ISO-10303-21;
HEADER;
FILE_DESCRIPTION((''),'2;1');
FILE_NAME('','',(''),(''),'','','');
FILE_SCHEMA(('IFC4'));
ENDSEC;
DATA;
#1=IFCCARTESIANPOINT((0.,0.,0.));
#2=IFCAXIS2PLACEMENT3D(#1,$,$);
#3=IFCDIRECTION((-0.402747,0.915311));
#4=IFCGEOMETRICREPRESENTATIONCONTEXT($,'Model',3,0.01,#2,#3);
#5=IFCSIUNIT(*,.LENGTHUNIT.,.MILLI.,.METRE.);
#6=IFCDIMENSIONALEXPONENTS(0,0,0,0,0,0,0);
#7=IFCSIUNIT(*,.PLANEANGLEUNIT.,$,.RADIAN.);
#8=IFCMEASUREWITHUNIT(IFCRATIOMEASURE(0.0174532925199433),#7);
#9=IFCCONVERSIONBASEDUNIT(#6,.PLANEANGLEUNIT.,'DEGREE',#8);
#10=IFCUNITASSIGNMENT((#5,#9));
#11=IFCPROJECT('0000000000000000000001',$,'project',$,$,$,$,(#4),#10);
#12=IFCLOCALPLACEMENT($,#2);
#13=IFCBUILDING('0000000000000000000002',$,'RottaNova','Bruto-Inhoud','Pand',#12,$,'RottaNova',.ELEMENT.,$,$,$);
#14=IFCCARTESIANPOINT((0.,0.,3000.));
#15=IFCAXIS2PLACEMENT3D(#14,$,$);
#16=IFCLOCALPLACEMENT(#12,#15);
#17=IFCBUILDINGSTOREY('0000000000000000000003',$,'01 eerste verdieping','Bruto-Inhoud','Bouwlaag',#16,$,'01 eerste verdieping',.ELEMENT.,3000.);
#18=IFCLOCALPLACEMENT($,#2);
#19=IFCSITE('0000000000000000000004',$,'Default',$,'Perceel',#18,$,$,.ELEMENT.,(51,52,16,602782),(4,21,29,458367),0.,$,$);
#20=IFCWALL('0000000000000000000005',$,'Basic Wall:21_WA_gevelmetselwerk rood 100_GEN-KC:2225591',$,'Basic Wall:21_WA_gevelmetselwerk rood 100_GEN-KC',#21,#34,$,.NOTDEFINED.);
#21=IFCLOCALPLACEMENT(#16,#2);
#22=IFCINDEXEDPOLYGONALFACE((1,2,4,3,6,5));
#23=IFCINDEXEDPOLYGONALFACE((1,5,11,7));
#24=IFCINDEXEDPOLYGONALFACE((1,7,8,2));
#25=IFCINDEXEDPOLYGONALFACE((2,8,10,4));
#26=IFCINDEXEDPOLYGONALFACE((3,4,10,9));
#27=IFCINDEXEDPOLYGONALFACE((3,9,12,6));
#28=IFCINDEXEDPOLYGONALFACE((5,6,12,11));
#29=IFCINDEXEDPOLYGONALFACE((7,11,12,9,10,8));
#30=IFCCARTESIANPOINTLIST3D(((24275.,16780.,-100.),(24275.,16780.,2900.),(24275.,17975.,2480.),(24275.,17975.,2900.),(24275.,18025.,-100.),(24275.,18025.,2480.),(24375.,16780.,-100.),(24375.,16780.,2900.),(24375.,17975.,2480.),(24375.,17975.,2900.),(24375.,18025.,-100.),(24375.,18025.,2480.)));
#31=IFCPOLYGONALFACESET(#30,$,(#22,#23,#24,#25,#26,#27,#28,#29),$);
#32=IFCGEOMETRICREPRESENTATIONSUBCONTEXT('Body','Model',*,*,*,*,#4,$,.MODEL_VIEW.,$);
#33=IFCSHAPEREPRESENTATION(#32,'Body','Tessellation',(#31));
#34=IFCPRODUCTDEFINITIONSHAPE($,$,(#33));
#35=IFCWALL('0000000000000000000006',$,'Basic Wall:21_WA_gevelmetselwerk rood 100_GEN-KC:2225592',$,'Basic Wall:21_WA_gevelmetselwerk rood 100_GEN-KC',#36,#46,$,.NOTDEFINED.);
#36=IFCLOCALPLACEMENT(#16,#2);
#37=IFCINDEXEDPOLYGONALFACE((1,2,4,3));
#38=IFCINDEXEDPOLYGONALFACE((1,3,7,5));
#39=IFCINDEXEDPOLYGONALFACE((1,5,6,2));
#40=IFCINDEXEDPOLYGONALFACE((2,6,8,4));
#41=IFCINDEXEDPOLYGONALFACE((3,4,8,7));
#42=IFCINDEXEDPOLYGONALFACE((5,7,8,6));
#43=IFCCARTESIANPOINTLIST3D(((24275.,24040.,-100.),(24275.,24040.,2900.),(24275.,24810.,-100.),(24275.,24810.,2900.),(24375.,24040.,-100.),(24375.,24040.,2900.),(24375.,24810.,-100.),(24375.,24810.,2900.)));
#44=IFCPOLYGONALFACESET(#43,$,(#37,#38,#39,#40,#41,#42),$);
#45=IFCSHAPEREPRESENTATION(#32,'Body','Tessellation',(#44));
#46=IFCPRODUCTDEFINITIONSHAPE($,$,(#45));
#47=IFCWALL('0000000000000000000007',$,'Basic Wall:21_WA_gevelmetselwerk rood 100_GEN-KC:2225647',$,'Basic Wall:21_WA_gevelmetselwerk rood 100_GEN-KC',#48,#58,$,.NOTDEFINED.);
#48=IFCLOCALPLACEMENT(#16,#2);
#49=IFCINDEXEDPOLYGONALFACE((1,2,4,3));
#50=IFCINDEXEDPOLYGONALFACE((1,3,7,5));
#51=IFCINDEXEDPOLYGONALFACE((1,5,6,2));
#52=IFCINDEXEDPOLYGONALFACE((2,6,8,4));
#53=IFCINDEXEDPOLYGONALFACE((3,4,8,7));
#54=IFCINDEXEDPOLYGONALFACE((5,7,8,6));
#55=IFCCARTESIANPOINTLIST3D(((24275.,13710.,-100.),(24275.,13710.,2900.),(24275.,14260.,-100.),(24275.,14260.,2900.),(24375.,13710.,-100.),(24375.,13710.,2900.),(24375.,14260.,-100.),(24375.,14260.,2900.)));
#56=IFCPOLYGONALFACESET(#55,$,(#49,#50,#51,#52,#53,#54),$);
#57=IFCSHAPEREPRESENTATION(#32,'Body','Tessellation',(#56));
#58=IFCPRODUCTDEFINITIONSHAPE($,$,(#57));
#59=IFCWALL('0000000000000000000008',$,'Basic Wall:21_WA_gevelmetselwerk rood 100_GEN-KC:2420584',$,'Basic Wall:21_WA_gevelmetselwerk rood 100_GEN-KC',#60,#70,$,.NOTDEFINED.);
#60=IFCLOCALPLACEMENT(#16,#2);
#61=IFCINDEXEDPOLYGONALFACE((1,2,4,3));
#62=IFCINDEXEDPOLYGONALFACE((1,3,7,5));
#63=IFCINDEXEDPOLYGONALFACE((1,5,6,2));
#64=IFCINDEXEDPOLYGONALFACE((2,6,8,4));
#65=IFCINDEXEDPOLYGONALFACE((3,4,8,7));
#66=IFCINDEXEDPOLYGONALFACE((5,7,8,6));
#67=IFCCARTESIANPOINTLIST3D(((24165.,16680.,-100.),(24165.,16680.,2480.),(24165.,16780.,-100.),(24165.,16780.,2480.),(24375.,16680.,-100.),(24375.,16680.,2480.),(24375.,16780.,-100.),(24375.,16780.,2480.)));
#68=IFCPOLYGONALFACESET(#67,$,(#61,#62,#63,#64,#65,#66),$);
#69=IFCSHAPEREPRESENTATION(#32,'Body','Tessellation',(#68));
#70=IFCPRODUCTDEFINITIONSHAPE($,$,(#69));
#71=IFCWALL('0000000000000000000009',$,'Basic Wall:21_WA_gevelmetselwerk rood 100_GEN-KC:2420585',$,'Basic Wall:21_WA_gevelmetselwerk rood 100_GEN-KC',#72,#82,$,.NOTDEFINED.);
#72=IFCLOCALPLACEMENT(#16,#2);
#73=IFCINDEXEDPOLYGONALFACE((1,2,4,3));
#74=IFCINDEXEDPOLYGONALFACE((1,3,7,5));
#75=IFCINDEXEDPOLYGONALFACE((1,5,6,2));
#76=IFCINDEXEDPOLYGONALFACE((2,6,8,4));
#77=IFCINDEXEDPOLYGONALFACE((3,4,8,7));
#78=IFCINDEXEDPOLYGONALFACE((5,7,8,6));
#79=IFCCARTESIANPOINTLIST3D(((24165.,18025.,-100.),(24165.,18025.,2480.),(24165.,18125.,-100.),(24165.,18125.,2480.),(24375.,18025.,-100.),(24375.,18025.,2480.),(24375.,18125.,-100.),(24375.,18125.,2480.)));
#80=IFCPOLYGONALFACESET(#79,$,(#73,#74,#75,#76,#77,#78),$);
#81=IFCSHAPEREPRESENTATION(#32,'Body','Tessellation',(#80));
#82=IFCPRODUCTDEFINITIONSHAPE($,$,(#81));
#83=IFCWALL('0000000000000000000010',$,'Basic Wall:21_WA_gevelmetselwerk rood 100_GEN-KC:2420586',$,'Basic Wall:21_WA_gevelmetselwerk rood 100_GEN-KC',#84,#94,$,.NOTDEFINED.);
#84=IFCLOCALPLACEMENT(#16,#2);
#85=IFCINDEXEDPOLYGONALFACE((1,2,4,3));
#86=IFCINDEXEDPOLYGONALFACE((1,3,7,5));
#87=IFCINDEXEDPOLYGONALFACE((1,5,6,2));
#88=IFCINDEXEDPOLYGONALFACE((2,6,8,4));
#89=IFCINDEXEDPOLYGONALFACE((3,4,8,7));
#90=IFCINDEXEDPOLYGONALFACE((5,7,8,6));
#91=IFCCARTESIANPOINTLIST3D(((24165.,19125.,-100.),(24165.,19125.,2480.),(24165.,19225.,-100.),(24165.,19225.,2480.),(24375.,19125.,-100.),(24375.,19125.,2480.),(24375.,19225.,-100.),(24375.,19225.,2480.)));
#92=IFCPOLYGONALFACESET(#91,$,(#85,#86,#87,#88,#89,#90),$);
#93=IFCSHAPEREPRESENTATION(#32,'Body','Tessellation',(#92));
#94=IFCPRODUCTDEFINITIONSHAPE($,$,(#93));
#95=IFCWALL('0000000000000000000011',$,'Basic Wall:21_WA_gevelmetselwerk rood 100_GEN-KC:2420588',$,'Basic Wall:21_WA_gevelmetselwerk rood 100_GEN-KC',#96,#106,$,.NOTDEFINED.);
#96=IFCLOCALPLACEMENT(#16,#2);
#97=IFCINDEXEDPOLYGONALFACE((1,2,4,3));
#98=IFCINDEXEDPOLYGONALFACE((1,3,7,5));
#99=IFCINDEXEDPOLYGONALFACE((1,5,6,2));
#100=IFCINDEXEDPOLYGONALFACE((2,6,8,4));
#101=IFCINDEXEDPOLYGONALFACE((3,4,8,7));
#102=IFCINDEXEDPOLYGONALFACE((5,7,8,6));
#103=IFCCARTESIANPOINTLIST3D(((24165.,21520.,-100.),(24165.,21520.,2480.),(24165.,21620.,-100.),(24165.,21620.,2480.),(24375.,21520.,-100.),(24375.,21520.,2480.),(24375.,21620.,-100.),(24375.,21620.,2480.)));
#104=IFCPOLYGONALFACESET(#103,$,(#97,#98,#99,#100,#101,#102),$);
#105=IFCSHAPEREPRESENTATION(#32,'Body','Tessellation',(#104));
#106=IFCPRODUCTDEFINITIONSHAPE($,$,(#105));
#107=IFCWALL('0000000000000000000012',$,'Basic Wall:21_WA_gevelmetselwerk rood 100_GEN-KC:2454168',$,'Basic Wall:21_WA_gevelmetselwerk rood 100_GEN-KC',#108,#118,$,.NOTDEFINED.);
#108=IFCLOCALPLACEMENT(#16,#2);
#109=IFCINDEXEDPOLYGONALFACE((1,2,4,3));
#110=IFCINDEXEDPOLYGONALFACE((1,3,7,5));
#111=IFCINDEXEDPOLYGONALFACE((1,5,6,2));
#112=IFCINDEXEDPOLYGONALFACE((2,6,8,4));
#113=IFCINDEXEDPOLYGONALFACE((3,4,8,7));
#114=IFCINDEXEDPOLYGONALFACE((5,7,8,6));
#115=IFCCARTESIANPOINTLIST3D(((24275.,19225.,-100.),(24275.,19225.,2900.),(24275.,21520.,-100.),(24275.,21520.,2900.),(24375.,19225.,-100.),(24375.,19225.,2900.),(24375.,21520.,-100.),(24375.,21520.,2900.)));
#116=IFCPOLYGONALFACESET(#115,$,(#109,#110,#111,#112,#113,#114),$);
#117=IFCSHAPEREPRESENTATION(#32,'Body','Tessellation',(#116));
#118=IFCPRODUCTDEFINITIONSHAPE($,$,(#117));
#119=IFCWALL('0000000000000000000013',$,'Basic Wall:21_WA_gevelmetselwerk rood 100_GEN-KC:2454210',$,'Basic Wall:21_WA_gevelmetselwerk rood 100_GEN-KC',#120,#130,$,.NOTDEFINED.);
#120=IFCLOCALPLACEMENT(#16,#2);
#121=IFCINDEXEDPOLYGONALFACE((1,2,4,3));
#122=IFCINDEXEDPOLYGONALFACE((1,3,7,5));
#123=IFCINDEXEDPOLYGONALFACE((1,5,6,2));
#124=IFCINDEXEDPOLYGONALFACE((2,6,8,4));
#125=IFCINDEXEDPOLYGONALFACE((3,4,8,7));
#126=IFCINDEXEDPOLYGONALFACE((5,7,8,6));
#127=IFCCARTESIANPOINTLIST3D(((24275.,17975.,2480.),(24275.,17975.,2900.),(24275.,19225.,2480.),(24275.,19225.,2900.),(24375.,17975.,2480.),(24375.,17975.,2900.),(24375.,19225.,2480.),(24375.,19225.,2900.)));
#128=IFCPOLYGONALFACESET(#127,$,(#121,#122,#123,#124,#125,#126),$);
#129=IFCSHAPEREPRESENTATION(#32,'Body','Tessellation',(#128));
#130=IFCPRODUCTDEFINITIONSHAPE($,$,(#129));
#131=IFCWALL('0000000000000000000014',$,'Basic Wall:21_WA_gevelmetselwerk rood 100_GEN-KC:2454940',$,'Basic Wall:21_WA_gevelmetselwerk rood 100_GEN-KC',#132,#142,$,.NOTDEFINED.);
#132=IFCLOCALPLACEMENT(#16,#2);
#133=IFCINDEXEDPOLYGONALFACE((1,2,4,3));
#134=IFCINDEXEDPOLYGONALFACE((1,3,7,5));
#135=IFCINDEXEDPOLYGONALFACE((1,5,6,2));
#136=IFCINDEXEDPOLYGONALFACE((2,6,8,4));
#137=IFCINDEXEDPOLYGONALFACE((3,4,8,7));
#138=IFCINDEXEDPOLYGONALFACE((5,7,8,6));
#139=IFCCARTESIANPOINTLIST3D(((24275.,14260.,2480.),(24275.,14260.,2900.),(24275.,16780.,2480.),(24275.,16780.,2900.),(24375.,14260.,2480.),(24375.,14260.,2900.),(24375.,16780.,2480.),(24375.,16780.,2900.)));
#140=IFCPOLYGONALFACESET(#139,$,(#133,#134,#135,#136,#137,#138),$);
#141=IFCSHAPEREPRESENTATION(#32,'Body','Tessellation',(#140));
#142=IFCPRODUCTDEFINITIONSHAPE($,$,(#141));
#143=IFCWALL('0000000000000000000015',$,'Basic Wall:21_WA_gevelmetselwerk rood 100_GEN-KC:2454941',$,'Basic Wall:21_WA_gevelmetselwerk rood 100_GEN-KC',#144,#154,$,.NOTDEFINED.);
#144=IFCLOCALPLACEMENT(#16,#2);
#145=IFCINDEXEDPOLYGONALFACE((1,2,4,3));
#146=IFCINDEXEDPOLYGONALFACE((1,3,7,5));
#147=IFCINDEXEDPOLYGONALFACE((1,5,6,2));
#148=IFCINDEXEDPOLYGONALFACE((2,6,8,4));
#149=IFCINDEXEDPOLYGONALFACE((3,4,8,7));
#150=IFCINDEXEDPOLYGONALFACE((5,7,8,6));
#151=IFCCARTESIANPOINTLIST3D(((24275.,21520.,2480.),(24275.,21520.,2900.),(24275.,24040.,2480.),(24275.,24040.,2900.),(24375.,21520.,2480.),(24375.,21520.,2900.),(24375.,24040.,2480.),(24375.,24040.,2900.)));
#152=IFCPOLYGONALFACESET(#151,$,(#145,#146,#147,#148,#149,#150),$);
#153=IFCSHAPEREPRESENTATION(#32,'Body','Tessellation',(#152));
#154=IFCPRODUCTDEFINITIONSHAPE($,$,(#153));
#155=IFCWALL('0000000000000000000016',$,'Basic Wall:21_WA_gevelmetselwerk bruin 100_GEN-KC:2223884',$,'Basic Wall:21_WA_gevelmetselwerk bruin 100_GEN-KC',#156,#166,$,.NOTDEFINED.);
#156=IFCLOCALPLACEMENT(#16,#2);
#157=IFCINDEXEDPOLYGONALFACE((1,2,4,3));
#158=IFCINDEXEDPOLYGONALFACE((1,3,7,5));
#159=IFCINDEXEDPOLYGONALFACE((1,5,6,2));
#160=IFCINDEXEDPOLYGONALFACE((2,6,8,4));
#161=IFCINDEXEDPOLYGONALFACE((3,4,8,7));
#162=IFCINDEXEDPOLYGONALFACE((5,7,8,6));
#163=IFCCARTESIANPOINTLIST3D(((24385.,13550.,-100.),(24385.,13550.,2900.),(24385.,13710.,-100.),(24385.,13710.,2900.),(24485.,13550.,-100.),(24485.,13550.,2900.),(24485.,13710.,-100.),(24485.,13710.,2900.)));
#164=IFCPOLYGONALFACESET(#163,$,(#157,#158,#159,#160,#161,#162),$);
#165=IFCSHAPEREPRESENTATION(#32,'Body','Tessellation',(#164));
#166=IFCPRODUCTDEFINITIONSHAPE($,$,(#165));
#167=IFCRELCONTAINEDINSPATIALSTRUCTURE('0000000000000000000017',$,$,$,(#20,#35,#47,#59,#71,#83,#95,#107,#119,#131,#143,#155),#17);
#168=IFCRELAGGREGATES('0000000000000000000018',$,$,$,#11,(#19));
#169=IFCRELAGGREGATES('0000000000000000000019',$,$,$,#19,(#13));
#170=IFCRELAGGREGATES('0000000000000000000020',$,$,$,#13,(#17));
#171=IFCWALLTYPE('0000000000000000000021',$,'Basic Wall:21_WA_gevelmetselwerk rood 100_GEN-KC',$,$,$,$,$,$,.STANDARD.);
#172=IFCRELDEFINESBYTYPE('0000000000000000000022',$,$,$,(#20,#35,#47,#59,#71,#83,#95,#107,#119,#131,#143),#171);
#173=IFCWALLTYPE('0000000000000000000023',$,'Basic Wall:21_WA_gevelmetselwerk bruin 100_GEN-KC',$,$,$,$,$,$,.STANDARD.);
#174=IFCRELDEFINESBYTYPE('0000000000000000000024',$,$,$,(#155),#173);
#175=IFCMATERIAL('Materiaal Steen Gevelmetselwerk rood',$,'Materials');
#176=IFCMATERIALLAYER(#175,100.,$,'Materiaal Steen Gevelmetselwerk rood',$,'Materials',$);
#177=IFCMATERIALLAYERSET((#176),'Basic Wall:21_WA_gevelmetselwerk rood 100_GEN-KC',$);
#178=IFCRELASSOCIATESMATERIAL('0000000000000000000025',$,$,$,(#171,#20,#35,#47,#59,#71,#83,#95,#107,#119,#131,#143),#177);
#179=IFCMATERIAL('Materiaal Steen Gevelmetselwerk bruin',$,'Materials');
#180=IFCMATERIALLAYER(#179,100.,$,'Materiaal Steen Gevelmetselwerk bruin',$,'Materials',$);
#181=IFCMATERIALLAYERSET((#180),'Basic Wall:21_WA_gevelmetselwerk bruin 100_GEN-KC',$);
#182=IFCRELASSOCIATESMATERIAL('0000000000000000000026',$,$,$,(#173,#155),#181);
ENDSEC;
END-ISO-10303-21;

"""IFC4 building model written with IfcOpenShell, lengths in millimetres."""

from ifc_helpers import new_model, entity, si_unit, converted_unit, direction, frame, frame_2d, origin, place, context, subcontext, project, spatial, polyline, rectangle, extrude, clip, bounded_halfspace, material, layer, layer_set, type_object, element, save


model = new_model("IFC4")

# Units and contexts
model_context = context("Model", 3, precision=0.01, world=origin(), true_north=direction((-0.402747, 0.915311)))
body_context = subcontext(model_context, "Body", "Model", "MODEL_VIEW")
ifc_project = project(units=[si_unit("LENGTHUNIT", "METRE", prefix="MILLI"), converted_unit("PLANEANGLEUNIT", "DEGREE", entity("IfcRatioMeasure", 0.0174532925199433), si_unit("PLANEANGLEUNIT", "RADIAN"), dimensions=[0, 0, 0, 0, 0, 0, 0])], contexts=[model_context])

# Site, building, storey
site_placement = place(None, origin())
site = spatial("IfcSite", under=ifc_project, at=site_placement, Name="Default", ObjectType="Perceel", CompositionType="ELEMENT", RefLatitude=(51, 52, 16, 602782), RefLongitude=(4, 21, 29, 458367), RefElevation=0.0)
building_placement = place(None, origin())
building = spatial("IfcBuilding", under=site, at=building_placement, Name="RottaNova", Description="Bruto-Inhoud", ObjectType="Pand", LongName="RottaNova", CompositionType="ELEMENT")
storey_placement = place(building_placement, frame((0.0, 0.0, 3000.0)))
storey = spatial("IfcBuildingStorey", under=building, at=storey_placement, Name="01 eerste verdieping", Description="Bruto-Inhoud", ObjectType="Bouwlaag", LongName="01 eerste verdieping", CompositionType="ELEMENT", Elevation=3000.0)

# Walls
ifc_material_1 = material(Name="Materiaal Steen Gevelmetselwerk rood", Category="Materials")
ifc_layer_1 = layer(ifc_material_1, 100.0, Name="Materiaal Steen Gevelmetselwerk rood", Category="Materials")
ifc_layer_set_1 = layer_set([ifc_layer_1], Name="Basic Wall:21_WA_gevelmetselwerk rood 100_GEN-KC")
wall_type_1 = type_object("IfcWallType", Name="Basic Wall:21_WA_gevelmetselwerk rood 100_GEN-KC", PredefinedType="STANDARD", material=ifc_layer_set_1)
wall_1_placement = place(storey_placement, frame((24325.0, 16780.0, -100.0), z_axis=(0.0, 0.0, 1.0), x_axis=(0.0, 1.0, 0.0)))
element("IfcWall", 1, at=wall_1_placement, inside=storey, type_object=wall_type_1, material=ifc_layer_set_1, Name="Basic Wall:21_WA_gevelmetselwerk rood 100_GEN-KC:2225591", ObjectType="Basic Wall:21_WA_gevelmetselwerk rood 100_GEN-KC", PredefinedType="NOTDEFINED", context=body_context, shape_type="Clipping", body=[
    clip(clip(extrude(rectangle(XDim=1245.0, YDim=100.0, at=frame_2d((622.5, 0.0), x_axis=(-1.0, 0.0))), origin(), (0.0, 0.0, 1.0), 3000.0), bounded_halfspace(frame((1195.0, 50.0, 2580.0), z_axis=(0.0, 0.0, -1.0), x_axis=(0.0, 1.0, 0.0)), True, frame((1195.0, 50.0, 2580.0), z_axis=(0.0, 0.0, -1.0), x_axis=(0.0, 1.0, 0.0)), polyline([(0.0, 0.0), (0.0, 50.0), (-100.0, 50.0), (-100.0, 0.0), (0.0, 0.0)]))), bounded_halfspace(frame((1195.0, -50.0, 2580.0), z_axis=(-1.0, 0.0, 0.0), x_axis=(0.0, 1.0, 0.0)), True, frame((1195.0, -50.0, 2580.0), z_axis=(-1.0, 0.0, 0.0), x_axis=(0.0, 1.0, 0.0)), polyline([(0.0, 0.0), (0.0, -128016.0), (30480.0, -128016.0), (30480.0, 0.0), (0.0, 0.0)]))),
])
wall_2_placement = place(storey_placement, frame((24325.0, 24810.0, -100.0), z_axis=(0.0, 0.0, 1.0), x_axis=(0.0, -1.0, 0.0)))
element("IfcWall", 2, at=wall_2_placement, inside=storey, type_object=wall_type_1, material=ifc_layer_set_1, Name="Basic Wall:21_WA_gevelmetselwerk rood 100_GEN-KC:2225592", ObjectType="Basic Wall:21_WA_gevelmetselwerk rood 100_GEN-KC", PredefinedType="NOTDEFINED", context=body_context, shape_type="SweptSolid", body=[
    extrude(rectangle(XDim=770.0, YDim=100.0, at=frame_2d((385.0, 0.0), x_axis=(-1.0, 0.0))), origin(), (0.0, 0.0, 1.0), 3000.0),
])
wall_3_placement = place(storey_placement, frame((24325.0, 13710.0, -100.0), z_axis=(0.0, 0.0, 1.0), x_axis=(0.0, 1.0, 0.0)))
element("IfcWall", 3, at=wall_3_placement, inside=storey, type_object=wall_type_1, material=ifc_layer_set_1, Name="Basic Wall:21_WA_gevelmetselwerk rood 100_GEN-KC:2225647", ObjectType="Basic Wall:21_WA_gevelmetselwerk rood 100_GEN-KC", PredefinedType="NOTDEFINED", context=body_context, shape_type="SweptSolid", body=[
    extrude(rectangle(XDim=550.0, YDim=100.0, at=frame_2d((275.0, 0.0), x_axis=(-1.0, 0.0))), origin(), (0.0, 0.0, 1.0), 3000.0),
])
wall_4_placement = place(storey_placement, frame((24375.0, 16730.0, -100.0), z_axis=(0.0, 0.0, 1.0), x_axis=(-1.0, 0.0, 0.0)))
element("IfcWall", 4, at=wall_4_placement, inside=storey, type_object=wall_type_1, material=ifc_layer_set_1, Name="Basic Wall:21_WA_gevelmetselwerk rood 100_GEN-KC:2420584", ObjectType="Basic Wall:21_WA_gevelmetselwerk rood 100_GEN-KC", PredefinedType="NOTDEFINED", context=body_context, shape_type="SweptSolid", body=[
    extrude(rectangle(XDim=210.0, YDim=100.0, at=frame_2d((105.0, 0.0), x_axis=(-1.0, 0.0))), origin(), (0.0, 0.0, 1.0), 2580.0),
])
wall_5_placement = place(storey_placement, frame((24375.0, 18075.0, -100.0), z_axis=(0.0, 0.0, 1.0), x_axis=(-1.0, 0.0, 0.0)))
element("IfcWall", 5, at=wall_5_placement, inside=storey, type_object=wall_type_1, material=ifc_layer_set_1, Name="Basic Wall:21_WA_gevelmetselwerk rood 100_GEN-KC:2420585", ObjectType="Basic Wall:21_WA_gevelmetselwerk rood 100_GEN-KC", PredefinedType="NOTDEFINED", context=body_context, shape_type="SweptSolid", body=[
    extrude(rectangle(XDim=210.0, YDim=100.0, at=frame_2d((105.0, 0.0), x_axis=(-1.0, 0.0))), origin(), (0.0, 0.0, 1.0), 2580.0),
])
wall_6_placement = place(storey_placement, frame((24375.0, 19175.0, -100.0), z_axis=(0.0, 0.0, 1.0), x_axis=(-1.0, 0.0, 0.0)))
element("IfcWall", 6, at=wall_6_placement, inside=storey, type_object=wall_type_1, material=ifc_layer_set_1, Name="Basic Wall:21_WA_gevelmetselwerk rood 100_GEN-KC:2420586", ObjectType="Basic Wall:21_WA_gevelmetselwerk rood 100_GEN-KC", PredefinedType="NOTDEFINED", context=body_context, shape_type="SweptSolid", body=[
    extrude(rectangle(XDim=210.0, YDim=100.0, at=frame_2d((105.0, 0.0), x_axis=(-1.0, 0.0))), origin(), (0.0, 0.0, 1.0), 2580.0),
])
wall_7_placement = place(storey_placement, frame((24375.0, 21570.0, -100.0), z_axis=(0.0, 0.0, 1.0), x_axis=(-1.0, 0.0, 0.0)))
element("IfcWall", 7, at=wall_7_placement, inside=storey, type_object=wall_type_1, material=ifc_layer_set_1, Name="Basic Wall:21_WA_gevelmetselwerk rood 100_GEN-KC:2420588", ObjectType="Basic Wall:21_WA_gevelmetselwerk rood 100_GEN-KC", PredefinedType="NOTDEFINED", context=body_context, shape_type="SweptSolid", body=[
    extrude(rectangle(XDim=210.0, YDim=100.0, at=frame_2d((105.0, 0.0), x_axis=(-1.0, 0.0))), origin(), (0.0, 0.0, 1.0), 2580.0),
])
wall_8_placement = place(storey_placement, frame((24325.0, 19225.0, -100.0), z_axis=(0.0, 0.0, 1.0), x_axis=(0.0, 1.0, 0.0)))
element("IfcWall", 8, at=wall_8_placement, inside=storey, type_object=wall_type_1, material=ifc_layer_set_1, Name="Basic Wall:21_WA_gevelmetselwerk rood 100_GEN-KC:2454168", ObjectType="Basic Wall:21_WA_gevelmetselwerk rood 100_GEN-KC", PredefinedType="NOTDEFINED", context=body_context, shape_type="SweptSolid", body=[
    extrude(rectangle(XDim=2295.0, YDim=100.0, at=frame_2d((1147.5, 0.0), x_axis=(-1.0, 0.0))), origin(), (0.0, 0.0, 1.0), 3000.0),
])
wall_9_placement = place(storey_placement, frame((24325.0, 17975.0, 2480.0), z_axis=(0.0, 0.0, 1.0), x_axis=(0.0, 1.0, 0.0)))
element("IfcWall", 9, at=wall_9_placement, inside=storey, type_object=wall_type_1, material=ifc_layer_set_1, Name="Basic Wall:21_WA_gevelmetselwerk rood 100_GEN-KC:2454210", ObjectType="Basic Wall:21_WA_gevelmetselwerk rood 100_GEN-KC", PredefinedType="NOTDEFINED", context=body_context, shape_type="SweptSolid", body=[
    extrude(rectangle(XDim=1250.0, YDim=100.0, at=frame_2d((625.0, 0.0), x_axis=(-1.0, 0.0))), origin(), (0.0, 0.0, 1.0), 420.0),
])
wall_10_placement = place(storey_placement, frame((24325.0, 14260.0, 2480.0), z_axis=(0.0, 0.0, 1.0), x_axis=(0.0, 1.0, 0.0)))
element("IfcWall", 10, at=wall_10_placement, inside=storey, type_object=wall_type_1, material=ifc_layer_set_1, Name="Basic Wall:21_WA_gevelmetselwerk rood 100_GEN-KC:2454940", ObjectType="Basic Wall:21_WA_gevelmetselwerk rood 100_GEN-KC", PredefinedType="NOTDEFINED", context=body_context, shape_type="Clipping", body=[
    clip(extrude(rectangle(XDim=2520.0, YDim=100.0, at=frame_2d((1260.0, 0.0), x_axis=(-1.0, 0.0))), origin(), (0.0, 0.0, 1.0), 420.0), bounded_halfspace(frame((2520.0, -50.0, 420.0), z_axis=(1.0, 0.0, 0.0), x_axis=(0.0, 1.0, 0.0)), False, frame((2520.0, -50.0, 420.0), z_axis=(1.0, 0.0, 0.0), x_axis=(0.0, 1.0, 0.0)), polyline([(0.0, 0.0), (0.0, -128016.0), (30480.0, -128016.0), (30480.0, 0.0), (0.0, 0.0)]))),
])
wall_11_placement = place(storey_placement, frame((24325.0, 24040.0, 2480.0), z_axis=(0.0, 0.0, 1.0), x_axis=(0.0, -1.0, 0.0)))
element("IfcWall", 11, at=wall_11_placement, inside=storey, type_object=wall_type_1, material=ifc_layer_set_1, Name="Basic Wall:21_WA_gevelmetselwerk rood 100_GEN-KC:2454941", ObjectType="Basic Wall:21_WA_gevelmetselwerk rood 100_GEN-KC", PredefinedType="NOTDEFINED", context=body_context, shape_type="Clipping", body=[
    clip(extrude(rectangle(XDim=2520.0, YDim=100.0, at=frame_2d((1260.0, 0.0), x_axis=(-1.0, 0.0))), origin(), (0.0, 0.0, 1.0), 420.0), bounded_halfspace(frame((2520.0, -50.0, 420.0), z_axis=(1.0, 0.0, 0.0), x_axis=(0.0, 1.0, 0.0)), False, frame((2520.0, -50.0, 420.0), z_axis=(1.0, 0.0, 0.0), x_axis=(0.0, 1.0, 0.0)), polyline([(0.0, 0.0), (0.0, -128016.0), (30480.0, -128016.0), (30480.0, 0.0), (0.0, 0.0)]))),
])
ifc_material_2 = material(Name="Materiaal Steen Gevelmetselwerk bruin", Category="Materials")
ifc_layer_2 = layer(ifc_material_2, 100.0, Name="Materiaal Steen Gevelmetselwerk bruin", Category="Materials")
ifc_layer_set_2 = layer_set([ifc_layer_2], Name="Basic Wall:21_WA_gevelmetselwerk bruin 100_GEN-KC")
wall_type_2 = type_object("IfcWallType", Name="Basic Wall:21_WA_gevelmetselwerk bruin 100_GEN-KC", PredefinedType="STANDARD", material=ifc_layer_set_2)
wall_12_placement = place(storey_placement, frame((24435.0, 13710.0, -100.0), z_axis=(0.0, 0.0, 1.0), x_axis=(0.0, -1.0, 0.0)))
element("IfcWall", 12, at=wall_12_placement, inside=storey, type_object=wall_type_2, material=ifc_layer_set_2, Name="Basic Wall:21_WA_gevelmetselwerk bruin 100_GEN-KC:2223884", ObjectType="Basic Wall:21_WA_gevelmetselwerk bruin 100_GEN-KC", PredefinedType="NOTDEFINED", context=body_context, shape_type="SweptSolid", body=[
    extrude(rectangle(XDim=160.0, YDim=100.0, at=frame_2d((80.0, 0.0), x_axis=(-1.0, 0.0))), origin(), (0.0, 0.0, 1.0), 3000.0),
])

save(model, "model.ifc")
